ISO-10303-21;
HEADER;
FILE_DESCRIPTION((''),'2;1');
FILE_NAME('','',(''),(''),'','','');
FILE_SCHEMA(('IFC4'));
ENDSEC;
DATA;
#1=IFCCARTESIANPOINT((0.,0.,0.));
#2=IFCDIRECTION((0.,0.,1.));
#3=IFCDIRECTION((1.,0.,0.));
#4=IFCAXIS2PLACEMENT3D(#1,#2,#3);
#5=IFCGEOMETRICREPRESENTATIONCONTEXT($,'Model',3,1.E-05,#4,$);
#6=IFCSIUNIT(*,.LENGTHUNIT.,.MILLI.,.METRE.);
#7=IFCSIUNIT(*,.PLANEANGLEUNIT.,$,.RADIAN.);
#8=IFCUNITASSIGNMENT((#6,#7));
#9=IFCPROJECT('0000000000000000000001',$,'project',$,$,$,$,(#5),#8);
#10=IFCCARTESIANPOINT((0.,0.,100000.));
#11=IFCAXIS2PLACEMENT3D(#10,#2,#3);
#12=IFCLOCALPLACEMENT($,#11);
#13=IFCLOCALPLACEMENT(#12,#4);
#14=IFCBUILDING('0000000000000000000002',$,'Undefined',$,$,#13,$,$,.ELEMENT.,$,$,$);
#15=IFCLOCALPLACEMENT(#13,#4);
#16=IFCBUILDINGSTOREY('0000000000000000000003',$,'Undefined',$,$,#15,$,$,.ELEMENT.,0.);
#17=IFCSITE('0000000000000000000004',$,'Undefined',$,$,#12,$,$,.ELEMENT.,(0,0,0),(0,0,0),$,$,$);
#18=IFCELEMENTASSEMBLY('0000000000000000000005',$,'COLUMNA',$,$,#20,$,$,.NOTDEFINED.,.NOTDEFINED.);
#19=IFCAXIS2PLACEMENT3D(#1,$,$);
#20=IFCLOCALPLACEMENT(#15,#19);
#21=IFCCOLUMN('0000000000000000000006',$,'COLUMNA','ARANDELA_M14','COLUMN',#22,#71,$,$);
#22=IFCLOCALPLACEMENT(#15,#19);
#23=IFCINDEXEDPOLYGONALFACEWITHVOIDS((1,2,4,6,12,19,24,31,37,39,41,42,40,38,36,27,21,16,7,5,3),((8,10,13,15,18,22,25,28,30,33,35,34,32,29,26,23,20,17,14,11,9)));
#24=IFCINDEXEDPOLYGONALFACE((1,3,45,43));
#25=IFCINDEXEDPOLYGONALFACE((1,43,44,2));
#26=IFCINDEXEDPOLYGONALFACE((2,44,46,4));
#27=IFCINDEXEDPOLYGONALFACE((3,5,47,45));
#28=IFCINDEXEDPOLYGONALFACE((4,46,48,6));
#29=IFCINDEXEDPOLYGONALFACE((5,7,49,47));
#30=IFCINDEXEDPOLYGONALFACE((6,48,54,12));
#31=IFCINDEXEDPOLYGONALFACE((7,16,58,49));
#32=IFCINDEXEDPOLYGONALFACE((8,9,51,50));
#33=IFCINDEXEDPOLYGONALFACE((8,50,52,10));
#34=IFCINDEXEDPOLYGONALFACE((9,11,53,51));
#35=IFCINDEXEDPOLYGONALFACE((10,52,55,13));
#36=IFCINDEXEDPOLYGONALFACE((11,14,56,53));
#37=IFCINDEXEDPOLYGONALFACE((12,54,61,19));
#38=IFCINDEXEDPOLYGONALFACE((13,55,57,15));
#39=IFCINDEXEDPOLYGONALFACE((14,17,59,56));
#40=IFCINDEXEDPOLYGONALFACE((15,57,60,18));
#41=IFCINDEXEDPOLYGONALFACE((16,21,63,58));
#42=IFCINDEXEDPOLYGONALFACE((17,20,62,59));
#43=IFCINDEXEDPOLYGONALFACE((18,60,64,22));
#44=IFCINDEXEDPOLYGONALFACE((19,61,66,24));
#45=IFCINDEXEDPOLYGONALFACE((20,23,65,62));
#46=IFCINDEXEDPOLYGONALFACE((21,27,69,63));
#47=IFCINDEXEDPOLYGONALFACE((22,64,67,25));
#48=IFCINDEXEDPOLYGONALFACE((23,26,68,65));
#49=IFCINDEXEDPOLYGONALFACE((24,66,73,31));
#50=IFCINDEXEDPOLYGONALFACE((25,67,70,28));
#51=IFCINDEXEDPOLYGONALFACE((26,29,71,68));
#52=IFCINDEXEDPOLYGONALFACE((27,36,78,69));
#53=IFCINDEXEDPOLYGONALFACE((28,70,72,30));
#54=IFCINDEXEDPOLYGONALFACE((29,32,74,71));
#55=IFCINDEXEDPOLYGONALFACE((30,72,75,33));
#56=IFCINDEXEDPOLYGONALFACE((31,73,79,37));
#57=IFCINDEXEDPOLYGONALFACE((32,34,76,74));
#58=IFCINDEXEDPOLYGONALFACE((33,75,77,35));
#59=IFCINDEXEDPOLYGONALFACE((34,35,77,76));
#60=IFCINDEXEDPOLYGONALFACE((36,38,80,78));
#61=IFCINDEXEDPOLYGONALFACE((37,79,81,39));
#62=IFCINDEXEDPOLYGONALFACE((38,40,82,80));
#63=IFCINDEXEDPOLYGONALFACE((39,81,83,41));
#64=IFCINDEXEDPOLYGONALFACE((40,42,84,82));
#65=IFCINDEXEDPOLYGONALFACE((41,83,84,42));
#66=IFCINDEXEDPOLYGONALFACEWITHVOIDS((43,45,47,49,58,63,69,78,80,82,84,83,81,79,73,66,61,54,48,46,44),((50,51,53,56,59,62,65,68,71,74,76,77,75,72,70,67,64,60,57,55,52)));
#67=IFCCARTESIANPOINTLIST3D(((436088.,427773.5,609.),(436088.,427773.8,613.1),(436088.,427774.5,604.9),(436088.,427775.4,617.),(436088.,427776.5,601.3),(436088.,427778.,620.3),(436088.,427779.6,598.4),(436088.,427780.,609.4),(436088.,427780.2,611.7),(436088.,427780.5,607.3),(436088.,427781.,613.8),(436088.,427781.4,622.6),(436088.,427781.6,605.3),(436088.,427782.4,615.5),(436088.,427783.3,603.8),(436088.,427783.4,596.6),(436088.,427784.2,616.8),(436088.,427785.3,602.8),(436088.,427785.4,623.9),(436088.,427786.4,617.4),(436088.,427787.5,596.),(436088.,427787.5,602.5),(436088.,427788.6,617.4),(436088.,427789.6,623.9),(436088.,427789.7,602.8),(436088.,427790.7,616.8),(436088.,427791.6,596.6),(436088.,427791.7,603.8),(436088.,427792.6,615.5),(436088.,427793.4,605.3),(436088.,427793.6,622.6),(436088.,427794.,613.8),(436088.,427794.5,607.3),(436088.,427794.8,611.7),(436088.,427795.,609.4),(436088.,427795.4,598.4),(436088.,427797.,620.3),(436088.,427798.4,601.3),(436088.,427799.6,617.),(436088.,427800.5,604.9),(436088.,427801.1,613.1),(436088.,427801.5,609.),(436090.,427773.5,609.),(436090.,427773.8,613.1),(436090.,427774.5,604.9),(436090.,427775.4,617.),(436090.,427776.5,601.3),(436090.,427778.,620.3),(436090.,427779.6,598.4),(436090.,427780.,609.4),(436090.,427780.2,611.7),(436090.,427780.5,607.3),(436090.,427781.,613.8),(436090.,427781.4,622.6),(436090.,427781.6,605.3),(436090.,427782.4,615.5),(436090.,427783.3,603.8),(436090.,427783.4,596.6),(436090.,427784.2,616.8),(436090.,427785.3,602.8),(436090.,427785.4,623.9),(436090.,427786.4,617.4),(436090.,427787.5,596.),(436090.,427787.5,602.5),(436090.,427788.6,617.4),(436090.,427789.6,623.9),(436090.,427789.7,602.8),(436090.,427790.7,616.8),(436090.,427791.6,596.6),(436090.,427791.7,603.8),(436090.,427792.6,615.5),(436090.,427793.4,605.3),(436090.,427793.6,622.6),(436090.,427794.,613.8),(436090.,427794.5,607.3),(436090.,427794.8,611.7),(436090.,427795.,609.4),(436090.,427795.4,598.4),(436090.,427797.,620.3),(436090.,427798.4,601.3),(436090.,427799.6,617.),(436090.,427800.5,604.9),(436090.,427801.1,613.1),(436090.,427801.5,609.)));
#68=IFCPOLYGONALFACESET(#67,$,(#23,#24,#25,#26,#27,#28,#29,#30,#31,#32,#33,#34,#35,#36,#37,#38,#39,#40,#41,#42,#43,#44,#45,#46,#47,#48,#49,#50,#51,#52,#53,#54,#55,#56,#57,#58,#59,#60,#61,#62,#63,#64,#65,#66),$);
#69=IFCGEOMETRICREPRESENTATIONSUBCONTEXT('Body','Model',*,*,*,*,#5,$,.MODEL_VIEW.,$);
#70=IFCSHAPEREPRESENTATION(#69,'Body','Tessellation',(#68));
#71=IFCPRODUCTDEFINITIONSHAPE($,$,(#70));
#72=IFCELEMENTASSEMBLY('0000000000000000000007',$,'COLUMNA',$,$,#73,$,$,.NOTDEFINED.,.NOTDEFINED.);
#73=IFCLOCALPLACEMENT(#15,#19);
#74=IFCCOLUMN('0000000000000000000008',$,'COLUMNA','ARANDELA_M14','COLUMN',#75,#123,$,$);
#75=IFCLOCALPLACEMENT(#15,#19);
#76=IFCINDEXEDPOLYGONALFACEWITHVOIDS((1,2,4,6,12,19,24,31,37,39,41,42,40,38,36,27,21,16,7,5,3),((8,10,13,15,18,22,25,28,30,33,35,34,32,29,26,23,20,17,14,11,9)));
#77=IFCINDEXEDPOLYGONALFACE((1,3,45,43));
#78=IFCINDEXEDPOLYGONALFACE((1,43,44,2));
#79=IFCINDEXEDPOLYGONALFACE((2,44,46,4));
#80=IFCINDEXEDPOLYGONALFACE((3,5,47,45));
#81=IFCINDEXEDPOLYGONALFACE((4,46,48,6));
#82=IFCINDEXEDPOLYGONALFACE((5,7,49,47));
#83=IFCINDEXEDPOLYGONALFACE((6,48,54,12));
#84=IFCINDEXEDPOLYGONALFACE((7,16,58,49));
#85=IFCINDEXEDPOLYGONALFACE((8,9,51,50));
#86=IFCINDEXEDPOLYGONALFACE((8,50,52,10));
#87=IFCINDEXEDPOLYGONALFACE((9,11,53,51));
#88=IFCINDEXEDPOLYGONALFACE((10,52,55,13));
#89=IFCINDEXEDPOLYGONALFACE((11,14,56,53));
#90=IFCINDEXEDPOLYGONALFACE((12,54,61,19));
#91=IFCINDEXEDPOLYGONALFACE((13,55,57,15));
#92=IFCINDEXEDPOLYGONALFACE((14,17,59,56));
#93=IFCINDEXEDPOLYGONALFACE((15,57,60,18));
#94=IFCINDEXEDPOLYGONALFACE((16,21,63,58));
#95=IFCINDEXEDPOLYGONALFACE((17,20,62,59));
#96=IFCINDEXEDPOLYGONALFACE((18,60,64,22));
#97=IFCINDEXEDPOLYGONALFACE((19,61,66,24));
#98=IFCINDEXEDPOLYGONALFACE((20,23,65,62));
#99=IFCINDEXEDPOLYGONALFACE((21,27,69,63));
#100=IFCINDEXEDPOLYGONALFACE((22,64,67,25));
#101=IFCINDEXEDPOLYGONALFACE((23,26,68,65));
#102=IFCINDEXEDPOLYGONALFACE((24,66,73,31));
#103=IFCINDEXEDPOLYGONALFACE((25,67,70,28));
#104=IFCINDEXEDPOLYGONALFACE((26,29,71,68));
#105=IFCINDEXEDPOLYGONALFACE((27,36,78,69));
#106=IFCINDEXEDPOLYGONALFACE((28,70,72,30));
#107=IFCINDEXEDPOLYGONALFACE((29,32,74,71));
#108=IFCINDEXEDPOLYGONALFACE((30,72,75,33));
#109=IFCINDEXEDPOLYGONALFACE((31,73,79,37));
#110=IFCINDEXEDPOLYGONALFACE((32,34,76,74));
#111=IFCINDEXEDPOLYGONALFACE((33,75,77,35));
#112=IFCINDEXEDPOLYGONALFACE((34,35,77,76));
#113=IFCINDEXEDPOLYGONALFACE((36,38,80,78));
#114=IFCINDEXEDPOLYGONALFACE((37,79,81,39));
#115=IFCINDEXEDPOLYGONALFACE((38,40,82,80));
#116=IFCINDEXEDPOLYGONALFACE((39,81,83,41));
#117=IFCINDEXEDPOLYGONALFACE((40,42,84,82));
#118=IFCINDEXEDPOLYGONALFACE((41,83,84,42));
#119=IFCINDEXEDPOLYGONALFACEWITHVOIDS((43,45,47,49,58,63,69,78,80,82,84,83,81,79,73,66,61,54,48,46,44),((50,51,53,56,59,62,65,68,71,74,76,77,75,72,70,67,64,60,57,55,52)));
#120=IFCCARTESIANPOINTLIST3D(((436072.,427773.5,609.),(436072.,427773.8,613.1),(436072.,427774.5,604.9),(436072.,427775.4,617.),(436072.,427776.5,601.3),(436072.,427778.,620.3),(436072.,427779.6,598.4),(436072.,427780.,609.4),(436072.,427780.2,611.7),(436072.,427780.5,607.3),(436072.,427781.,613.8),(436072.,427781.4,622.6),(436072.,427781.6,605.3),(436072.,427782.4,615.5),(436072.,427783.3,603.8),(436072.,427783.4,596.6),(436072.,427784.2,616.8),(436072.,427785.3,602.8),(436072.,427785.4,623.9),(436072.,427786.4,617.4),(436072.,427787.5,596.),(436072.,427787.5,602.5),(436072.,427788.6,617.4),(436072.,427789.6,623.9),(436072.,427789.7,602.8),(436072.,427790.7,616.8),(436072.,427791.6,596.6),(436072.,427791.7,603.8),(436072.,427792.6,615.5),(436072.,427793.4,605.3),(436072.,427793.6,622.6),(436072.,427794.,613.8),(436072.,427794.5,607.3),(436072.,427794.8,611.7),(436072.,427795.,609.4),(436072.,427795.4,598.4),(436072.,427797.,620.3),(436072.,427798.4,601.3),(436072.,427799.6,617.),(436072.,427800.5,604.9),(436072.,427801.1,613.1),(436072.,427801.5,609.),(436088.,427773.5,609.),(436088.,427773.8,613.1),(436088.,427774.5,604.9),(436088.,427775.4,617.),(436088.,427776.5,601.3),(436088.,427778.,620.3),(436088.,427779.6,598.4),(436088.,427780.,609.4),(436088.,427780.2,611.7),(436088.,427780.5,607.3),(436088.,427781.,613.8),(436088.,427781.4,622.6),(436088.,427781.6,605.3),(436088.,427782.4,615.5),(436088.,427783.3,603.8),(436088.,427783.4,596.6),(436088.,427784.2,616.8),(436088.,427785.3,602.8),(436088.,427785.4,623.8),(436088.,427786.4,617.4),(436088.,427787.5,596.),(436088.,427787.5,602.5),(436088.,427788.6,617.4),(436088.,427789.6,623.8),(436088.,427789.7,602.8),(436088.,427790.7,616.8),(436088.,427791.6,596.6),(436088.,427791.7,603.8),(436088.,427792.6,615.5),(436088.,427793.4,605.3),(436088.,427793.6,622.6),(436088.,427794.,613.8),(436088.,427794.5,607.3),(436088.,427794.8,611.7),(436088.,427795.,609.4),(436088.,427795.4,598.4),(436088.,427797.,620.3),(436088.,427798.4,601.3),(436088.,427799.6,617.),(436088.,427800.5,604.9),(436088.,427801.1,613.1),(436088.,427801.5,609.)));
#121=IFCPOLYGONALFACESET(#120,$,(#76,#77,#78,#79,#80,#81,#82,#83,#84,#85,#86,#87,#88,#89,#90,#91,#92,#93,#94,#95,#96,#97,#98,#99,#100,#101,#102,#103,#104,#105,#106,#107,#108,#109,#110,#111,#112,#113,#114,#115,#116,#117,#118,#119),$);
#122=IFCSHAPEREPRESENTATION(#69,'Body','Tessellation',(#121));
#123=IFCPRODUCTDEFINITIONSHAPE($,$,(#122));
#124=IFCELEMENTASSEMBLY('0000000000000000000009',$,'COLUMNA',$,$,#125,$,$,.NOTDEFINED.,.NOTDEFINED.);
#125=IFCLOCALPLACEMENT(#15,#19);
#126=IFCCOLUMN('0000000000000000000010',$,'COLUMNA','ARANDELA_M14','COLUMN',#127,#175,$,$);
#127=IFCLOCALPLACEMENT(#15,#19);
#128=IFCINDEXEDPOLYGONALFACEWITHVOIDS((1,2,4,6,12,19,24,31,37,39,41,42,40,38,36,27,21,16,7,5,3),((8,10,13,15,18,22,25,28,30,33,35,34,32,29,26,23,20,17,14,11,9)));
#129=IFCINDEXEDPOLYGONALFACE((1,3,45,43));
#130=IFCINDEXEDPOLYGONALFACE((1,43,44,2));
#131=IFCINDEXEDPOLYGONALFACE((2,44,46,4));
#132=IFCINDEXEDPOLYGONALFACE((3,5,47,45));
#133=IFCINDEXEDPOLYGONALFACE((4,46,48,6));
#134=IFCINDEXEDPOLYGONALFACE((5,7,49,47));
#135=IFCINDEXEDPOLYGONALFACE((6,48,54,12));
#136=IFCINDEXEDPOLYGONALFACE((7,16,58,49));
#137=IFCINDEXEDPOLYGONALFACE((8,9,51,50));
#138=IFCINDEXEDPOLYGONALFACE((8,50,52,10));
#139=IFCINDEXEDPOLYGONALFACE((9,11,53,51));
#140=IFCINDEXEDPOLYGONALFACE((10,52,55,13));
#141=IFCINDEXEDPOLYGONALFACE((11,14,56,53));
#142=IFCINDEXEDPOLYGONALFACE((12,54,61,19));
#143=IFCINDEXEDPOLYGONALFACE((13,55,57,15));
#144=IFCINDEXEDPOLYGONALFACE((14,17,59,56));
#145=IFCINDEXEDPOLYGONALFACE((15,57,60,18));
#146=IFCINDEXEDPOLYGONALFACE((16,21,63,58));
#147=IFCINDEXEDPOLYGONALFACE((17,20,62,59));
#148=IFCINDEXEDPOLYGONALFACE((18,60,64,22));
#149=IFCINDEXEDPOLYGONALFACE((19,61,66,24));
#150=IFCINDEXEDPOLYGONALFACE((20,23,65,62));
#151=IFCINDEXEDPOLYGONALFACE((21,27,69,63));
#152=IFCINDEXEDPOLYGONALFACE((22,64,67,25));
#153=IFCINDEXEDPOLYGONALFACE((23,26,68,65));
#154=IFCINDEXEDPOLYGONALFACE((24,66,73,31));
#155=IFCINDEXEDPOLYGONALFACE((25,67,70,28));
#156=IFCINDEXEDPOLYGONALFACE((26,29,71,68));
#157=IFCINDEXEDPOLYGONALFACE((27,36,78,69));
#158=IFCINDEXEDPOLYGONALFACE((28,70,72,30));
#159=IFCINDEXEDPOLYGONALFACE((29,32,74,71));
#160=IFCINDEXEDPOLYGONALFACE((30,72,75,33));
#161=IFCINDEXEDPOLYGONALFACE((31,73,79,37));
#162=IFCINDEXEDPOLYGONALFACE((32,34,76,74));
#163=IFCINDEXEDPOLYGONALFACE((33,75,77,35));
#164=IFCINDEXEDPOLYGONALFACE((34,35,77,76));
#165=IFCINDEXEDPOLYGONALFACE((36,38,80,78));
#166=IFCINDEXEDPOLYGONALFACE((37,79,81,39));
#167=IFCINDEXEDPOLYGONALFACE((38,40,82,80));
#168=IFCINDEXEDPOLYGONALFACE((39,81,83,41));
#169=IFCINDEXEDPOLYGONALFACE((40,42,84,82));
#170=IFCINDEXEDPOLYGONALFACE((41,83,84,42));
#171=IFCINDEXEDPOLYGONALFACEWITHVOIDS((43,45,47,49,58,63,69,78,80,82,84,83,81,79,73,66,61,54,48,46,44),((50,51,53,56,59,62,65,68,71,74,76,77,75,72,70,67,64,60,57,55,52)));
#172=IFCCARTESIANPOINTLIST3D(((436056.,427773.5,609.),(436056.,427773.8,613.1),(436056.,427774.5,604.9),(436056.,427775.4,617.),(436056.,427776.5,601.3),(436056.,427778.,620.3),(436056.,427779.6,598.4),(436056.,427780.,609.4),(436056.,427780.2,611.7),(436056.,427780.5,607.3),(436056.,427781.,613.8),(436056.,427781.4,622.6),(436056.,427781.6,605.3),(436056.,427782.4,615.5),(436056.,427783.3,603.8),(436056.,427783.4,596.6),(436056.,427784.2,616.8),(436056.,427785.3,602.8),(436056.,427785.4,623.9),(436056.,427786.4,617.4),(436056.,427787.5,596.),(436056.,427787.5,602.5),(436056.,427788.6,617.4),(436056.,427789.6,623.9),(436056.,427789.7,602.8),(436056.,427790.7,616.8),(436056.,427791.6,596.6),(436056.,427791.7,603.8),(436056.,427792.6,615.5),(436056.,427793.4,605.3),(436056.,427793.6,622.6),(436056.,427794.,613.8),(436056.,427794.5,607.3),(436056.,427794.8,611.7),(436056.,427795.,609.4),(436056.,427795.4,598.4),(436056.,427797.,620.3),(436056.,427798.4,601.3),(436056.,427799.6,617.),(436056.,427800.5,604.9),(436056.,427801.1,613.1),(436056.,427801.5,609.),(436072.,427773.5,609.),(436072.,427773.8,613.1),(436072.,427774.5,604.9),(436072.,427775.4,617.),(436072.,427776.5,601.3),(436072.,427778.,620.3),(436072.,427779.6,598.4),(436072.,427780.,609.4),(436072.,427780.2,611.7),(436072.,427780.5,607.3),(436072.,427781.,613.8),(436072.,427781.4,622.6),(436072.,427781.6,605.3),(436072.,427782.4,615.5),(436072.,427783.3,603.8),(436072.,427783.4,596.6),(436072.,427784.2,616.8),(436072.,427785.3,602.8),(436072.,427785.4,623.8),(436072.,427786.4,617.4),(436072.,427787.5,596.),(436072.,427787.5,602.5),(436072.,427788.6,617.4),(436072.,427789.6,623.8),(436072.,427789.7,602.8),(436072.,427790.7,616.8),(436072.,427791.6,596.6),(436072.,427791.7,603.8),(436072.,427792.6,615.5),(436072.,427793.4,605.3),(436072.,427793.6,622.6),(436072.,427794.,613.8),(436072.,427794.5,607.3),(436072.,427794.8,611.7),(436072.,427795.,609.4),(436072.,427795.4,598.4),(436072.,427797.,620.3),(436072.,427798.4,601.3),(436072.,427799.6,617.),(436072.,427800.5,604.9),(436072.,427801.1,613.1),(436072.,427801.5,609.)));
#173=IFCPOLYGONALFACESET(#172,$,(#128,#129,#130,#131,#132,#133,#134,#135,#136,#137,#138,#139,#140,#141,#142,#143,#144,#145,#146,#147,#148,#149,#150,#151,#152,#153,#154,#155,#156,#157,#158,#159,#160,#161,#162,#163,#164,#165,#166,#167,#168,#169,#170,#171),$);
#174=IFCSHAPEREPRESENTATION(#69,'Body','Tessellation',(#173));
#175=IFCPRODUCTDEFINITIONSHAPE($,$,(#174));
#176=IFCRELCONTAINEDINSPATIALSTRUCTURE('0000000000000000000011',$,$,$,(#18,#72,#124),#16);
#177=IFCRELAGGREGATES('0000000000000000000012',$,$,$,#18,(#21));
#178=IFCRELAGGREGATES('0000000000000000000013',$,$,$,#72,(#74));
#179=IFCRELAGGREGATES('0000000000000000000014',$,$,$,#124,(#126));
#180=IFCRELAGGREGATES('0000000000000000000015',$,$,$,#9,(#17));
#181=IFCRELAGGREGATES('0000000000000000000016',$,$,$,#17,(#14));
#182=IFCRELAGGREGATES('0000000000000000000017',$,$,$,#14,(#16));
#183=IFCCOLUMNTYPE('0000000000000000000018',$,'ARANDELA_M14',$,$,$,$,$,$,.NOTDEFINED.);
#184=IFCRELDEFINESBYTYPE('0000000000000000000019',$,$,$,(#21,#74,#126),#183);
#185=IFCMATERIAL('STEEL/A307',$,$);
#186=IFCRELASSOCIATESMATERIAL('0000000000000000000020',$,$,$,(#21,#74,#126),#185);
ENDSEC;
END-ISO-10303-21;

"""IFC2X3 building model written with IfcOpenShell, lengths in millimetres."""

from ifc_helpers import new_model, si_unit, frame, origin_with_axes, origin_2d_with_axis, place, context, subcontext, project, spatial, hollow_circle, extrude, material, type_object, element, aggregate, save


model = new_model("IFC2X3")

# Units and contexts
model_context = context("Model", 3, precision=1e-05, world=origin_with_axes())
body_context = subcontext(model_context, "Body", "Model", "MODEL_VIEW")
ifc_project = project(units=[si_unit("LENGTHUNIT", "METRE", prefix="MILLI"), si_unit("PLANEANGLEUNIT", "RADIAN")], contexts=[model_context])

# Site, building, storey
site_placement = place(None, frame((0.0, 0.0, 100000.0), z_axis=(0.0, 0.0, 1.0), x_axis=(1.0, 0.0, 0.0)))
site = spatial("IfcSite", under=ifc_project, at=site_placement, Name="Undefined", CompositionType="ELEMENT", RefLatitude=(0, 0, 0), RefLongitude=(0, 0, 0))
building_placement = place(site_placement, origin_with_axes())
building = spatial("IfcBuilding", under=site, at=building_placement, Name="Undefined", CompositionType="ELEMENT")
storey_placement = place(building_placement, origin_with_axes())
storey = spatial("IfcBuildingStorey", under=building, at=storey_placement, Name="Undefined", CompositionType="ELEMENT", Elevation=0.0)

# Element assemblies, columns
ifc_material_1 = material(Name="STEEL/A307")
column_type_1 = type_object("IfcColumnType", Name="ARANDELA_M14", PredefinedType="NOTDEFINED")
assembly_1_placement = place(storey_placement, origin_with_axes())
assembly_1 = element("IfcElementAssembly", 1, at=assembly_1_placement, inside=storey, Name="COLUMNA", AssemblyPlace="NOTDEFINED", PredefinedType="NOTDEFINED")
column_1_placement = place(assembly_1_placement, frame((436090.0, 427787.5, 610.0), z_axis=(-1.0, 0.0, 0.000285), x_axis=(0.0, 1.0, 0.0)))
column_1 = element("IfcColumn", 2, at=column_1_placement, type_object=column_type_1, material=ifc_material_1, Name="COLUMNA", Description="ARANDELA_M14", ObjectType="COLUMN", context=body_context, shape_type="SweptSolid", body=[
    extrude(hollow_circle(Radius=14.0, WallThickness=6.5, at=origin_2d_with_axis()), frame((0.0, 0.0, 2.0), z_axis=(0.0, 0.0, -1.0), x_axis=(0.0, 1.0, 0.0)), (0.0, 0.0, 1.0), 2.0),
])
aggregate(assembly_1, [column_1])
assembly_2_placement = place(storey_placement, origin_with_axes())
assembly_2 = element("IfcElementAssembly", 3, at=assembly_2_placement, inside=storey, Name="COLUMNA", AssemblyPlace="NOTDEFINED", PredefinedType="NOTDEFINED")
column_2_placement = place(assembly_2_placement, frame((436088.0, 427787.5, 610.0), z_axis=(-1.0, 0.0, 0.000285), x_axis=(0.0, 1.0, 0.0)))
column_2 = element("IfcColumn", 4, at=column_2_placement, type_object=column_type_1, material=ifc_material_1, Name="COLUMNA", Description="ARANDELA_M14", ObjectType="COLUMN", context=body_context, shape_type="SweptSolid", body=[
    extrude(hollow_circle(Radius=14.0, WallThickness=6.5, at=origin_2d_with_axis()), frame((0.0, 0.0, 16.0), z_axis=(0.0, 0.0, -1.0), x_axis=(0.0, 1.0, 0.0)), (0.0, 0.0, 1.0), 16.0),
])
aggregate(assembly_2, [column_2])
assembly_3_placement = place(storey_placement, origin_with_axes())
assembly_3 = element("IfcElementAssembly", 5, at=assembly_3_placement, inside=storey, Name="COLUMNA", AssemblyPlace="NOTDEFINED", PredefinedType="NOTDEFINED")
column_3_placement = place(assembly_3_placement, frame((436072.0, 427787.5, 610.0), z_axis=(-1.0, 0.0, 0.000285), x_axis=(0.0, 1.0, 0.0)))
column_3 = element("IfcColumn", 6, at=column_3_placement, type_object=column_type_1, material=ifc_material_1, Name="COLUMNA", Description="ARANDELA_M14", ObjectType="COLUMN", context=body_context, shape_type="SweptSolid", body=[
    extrude(hollow_circle(Radius=14.0, WallThickness=6.5, at=origin_2d_with_axis()), frame((0.0, 0.0, 16.0), z_axis=(0.0, 0.0, -1.0), x_axis=(0.0, 1.0, 0.0)), (0.0, 0.0, 1.0), 16.0),
])
aggregate(assembly_3, [column_3])

save(model, "model.ifc")
